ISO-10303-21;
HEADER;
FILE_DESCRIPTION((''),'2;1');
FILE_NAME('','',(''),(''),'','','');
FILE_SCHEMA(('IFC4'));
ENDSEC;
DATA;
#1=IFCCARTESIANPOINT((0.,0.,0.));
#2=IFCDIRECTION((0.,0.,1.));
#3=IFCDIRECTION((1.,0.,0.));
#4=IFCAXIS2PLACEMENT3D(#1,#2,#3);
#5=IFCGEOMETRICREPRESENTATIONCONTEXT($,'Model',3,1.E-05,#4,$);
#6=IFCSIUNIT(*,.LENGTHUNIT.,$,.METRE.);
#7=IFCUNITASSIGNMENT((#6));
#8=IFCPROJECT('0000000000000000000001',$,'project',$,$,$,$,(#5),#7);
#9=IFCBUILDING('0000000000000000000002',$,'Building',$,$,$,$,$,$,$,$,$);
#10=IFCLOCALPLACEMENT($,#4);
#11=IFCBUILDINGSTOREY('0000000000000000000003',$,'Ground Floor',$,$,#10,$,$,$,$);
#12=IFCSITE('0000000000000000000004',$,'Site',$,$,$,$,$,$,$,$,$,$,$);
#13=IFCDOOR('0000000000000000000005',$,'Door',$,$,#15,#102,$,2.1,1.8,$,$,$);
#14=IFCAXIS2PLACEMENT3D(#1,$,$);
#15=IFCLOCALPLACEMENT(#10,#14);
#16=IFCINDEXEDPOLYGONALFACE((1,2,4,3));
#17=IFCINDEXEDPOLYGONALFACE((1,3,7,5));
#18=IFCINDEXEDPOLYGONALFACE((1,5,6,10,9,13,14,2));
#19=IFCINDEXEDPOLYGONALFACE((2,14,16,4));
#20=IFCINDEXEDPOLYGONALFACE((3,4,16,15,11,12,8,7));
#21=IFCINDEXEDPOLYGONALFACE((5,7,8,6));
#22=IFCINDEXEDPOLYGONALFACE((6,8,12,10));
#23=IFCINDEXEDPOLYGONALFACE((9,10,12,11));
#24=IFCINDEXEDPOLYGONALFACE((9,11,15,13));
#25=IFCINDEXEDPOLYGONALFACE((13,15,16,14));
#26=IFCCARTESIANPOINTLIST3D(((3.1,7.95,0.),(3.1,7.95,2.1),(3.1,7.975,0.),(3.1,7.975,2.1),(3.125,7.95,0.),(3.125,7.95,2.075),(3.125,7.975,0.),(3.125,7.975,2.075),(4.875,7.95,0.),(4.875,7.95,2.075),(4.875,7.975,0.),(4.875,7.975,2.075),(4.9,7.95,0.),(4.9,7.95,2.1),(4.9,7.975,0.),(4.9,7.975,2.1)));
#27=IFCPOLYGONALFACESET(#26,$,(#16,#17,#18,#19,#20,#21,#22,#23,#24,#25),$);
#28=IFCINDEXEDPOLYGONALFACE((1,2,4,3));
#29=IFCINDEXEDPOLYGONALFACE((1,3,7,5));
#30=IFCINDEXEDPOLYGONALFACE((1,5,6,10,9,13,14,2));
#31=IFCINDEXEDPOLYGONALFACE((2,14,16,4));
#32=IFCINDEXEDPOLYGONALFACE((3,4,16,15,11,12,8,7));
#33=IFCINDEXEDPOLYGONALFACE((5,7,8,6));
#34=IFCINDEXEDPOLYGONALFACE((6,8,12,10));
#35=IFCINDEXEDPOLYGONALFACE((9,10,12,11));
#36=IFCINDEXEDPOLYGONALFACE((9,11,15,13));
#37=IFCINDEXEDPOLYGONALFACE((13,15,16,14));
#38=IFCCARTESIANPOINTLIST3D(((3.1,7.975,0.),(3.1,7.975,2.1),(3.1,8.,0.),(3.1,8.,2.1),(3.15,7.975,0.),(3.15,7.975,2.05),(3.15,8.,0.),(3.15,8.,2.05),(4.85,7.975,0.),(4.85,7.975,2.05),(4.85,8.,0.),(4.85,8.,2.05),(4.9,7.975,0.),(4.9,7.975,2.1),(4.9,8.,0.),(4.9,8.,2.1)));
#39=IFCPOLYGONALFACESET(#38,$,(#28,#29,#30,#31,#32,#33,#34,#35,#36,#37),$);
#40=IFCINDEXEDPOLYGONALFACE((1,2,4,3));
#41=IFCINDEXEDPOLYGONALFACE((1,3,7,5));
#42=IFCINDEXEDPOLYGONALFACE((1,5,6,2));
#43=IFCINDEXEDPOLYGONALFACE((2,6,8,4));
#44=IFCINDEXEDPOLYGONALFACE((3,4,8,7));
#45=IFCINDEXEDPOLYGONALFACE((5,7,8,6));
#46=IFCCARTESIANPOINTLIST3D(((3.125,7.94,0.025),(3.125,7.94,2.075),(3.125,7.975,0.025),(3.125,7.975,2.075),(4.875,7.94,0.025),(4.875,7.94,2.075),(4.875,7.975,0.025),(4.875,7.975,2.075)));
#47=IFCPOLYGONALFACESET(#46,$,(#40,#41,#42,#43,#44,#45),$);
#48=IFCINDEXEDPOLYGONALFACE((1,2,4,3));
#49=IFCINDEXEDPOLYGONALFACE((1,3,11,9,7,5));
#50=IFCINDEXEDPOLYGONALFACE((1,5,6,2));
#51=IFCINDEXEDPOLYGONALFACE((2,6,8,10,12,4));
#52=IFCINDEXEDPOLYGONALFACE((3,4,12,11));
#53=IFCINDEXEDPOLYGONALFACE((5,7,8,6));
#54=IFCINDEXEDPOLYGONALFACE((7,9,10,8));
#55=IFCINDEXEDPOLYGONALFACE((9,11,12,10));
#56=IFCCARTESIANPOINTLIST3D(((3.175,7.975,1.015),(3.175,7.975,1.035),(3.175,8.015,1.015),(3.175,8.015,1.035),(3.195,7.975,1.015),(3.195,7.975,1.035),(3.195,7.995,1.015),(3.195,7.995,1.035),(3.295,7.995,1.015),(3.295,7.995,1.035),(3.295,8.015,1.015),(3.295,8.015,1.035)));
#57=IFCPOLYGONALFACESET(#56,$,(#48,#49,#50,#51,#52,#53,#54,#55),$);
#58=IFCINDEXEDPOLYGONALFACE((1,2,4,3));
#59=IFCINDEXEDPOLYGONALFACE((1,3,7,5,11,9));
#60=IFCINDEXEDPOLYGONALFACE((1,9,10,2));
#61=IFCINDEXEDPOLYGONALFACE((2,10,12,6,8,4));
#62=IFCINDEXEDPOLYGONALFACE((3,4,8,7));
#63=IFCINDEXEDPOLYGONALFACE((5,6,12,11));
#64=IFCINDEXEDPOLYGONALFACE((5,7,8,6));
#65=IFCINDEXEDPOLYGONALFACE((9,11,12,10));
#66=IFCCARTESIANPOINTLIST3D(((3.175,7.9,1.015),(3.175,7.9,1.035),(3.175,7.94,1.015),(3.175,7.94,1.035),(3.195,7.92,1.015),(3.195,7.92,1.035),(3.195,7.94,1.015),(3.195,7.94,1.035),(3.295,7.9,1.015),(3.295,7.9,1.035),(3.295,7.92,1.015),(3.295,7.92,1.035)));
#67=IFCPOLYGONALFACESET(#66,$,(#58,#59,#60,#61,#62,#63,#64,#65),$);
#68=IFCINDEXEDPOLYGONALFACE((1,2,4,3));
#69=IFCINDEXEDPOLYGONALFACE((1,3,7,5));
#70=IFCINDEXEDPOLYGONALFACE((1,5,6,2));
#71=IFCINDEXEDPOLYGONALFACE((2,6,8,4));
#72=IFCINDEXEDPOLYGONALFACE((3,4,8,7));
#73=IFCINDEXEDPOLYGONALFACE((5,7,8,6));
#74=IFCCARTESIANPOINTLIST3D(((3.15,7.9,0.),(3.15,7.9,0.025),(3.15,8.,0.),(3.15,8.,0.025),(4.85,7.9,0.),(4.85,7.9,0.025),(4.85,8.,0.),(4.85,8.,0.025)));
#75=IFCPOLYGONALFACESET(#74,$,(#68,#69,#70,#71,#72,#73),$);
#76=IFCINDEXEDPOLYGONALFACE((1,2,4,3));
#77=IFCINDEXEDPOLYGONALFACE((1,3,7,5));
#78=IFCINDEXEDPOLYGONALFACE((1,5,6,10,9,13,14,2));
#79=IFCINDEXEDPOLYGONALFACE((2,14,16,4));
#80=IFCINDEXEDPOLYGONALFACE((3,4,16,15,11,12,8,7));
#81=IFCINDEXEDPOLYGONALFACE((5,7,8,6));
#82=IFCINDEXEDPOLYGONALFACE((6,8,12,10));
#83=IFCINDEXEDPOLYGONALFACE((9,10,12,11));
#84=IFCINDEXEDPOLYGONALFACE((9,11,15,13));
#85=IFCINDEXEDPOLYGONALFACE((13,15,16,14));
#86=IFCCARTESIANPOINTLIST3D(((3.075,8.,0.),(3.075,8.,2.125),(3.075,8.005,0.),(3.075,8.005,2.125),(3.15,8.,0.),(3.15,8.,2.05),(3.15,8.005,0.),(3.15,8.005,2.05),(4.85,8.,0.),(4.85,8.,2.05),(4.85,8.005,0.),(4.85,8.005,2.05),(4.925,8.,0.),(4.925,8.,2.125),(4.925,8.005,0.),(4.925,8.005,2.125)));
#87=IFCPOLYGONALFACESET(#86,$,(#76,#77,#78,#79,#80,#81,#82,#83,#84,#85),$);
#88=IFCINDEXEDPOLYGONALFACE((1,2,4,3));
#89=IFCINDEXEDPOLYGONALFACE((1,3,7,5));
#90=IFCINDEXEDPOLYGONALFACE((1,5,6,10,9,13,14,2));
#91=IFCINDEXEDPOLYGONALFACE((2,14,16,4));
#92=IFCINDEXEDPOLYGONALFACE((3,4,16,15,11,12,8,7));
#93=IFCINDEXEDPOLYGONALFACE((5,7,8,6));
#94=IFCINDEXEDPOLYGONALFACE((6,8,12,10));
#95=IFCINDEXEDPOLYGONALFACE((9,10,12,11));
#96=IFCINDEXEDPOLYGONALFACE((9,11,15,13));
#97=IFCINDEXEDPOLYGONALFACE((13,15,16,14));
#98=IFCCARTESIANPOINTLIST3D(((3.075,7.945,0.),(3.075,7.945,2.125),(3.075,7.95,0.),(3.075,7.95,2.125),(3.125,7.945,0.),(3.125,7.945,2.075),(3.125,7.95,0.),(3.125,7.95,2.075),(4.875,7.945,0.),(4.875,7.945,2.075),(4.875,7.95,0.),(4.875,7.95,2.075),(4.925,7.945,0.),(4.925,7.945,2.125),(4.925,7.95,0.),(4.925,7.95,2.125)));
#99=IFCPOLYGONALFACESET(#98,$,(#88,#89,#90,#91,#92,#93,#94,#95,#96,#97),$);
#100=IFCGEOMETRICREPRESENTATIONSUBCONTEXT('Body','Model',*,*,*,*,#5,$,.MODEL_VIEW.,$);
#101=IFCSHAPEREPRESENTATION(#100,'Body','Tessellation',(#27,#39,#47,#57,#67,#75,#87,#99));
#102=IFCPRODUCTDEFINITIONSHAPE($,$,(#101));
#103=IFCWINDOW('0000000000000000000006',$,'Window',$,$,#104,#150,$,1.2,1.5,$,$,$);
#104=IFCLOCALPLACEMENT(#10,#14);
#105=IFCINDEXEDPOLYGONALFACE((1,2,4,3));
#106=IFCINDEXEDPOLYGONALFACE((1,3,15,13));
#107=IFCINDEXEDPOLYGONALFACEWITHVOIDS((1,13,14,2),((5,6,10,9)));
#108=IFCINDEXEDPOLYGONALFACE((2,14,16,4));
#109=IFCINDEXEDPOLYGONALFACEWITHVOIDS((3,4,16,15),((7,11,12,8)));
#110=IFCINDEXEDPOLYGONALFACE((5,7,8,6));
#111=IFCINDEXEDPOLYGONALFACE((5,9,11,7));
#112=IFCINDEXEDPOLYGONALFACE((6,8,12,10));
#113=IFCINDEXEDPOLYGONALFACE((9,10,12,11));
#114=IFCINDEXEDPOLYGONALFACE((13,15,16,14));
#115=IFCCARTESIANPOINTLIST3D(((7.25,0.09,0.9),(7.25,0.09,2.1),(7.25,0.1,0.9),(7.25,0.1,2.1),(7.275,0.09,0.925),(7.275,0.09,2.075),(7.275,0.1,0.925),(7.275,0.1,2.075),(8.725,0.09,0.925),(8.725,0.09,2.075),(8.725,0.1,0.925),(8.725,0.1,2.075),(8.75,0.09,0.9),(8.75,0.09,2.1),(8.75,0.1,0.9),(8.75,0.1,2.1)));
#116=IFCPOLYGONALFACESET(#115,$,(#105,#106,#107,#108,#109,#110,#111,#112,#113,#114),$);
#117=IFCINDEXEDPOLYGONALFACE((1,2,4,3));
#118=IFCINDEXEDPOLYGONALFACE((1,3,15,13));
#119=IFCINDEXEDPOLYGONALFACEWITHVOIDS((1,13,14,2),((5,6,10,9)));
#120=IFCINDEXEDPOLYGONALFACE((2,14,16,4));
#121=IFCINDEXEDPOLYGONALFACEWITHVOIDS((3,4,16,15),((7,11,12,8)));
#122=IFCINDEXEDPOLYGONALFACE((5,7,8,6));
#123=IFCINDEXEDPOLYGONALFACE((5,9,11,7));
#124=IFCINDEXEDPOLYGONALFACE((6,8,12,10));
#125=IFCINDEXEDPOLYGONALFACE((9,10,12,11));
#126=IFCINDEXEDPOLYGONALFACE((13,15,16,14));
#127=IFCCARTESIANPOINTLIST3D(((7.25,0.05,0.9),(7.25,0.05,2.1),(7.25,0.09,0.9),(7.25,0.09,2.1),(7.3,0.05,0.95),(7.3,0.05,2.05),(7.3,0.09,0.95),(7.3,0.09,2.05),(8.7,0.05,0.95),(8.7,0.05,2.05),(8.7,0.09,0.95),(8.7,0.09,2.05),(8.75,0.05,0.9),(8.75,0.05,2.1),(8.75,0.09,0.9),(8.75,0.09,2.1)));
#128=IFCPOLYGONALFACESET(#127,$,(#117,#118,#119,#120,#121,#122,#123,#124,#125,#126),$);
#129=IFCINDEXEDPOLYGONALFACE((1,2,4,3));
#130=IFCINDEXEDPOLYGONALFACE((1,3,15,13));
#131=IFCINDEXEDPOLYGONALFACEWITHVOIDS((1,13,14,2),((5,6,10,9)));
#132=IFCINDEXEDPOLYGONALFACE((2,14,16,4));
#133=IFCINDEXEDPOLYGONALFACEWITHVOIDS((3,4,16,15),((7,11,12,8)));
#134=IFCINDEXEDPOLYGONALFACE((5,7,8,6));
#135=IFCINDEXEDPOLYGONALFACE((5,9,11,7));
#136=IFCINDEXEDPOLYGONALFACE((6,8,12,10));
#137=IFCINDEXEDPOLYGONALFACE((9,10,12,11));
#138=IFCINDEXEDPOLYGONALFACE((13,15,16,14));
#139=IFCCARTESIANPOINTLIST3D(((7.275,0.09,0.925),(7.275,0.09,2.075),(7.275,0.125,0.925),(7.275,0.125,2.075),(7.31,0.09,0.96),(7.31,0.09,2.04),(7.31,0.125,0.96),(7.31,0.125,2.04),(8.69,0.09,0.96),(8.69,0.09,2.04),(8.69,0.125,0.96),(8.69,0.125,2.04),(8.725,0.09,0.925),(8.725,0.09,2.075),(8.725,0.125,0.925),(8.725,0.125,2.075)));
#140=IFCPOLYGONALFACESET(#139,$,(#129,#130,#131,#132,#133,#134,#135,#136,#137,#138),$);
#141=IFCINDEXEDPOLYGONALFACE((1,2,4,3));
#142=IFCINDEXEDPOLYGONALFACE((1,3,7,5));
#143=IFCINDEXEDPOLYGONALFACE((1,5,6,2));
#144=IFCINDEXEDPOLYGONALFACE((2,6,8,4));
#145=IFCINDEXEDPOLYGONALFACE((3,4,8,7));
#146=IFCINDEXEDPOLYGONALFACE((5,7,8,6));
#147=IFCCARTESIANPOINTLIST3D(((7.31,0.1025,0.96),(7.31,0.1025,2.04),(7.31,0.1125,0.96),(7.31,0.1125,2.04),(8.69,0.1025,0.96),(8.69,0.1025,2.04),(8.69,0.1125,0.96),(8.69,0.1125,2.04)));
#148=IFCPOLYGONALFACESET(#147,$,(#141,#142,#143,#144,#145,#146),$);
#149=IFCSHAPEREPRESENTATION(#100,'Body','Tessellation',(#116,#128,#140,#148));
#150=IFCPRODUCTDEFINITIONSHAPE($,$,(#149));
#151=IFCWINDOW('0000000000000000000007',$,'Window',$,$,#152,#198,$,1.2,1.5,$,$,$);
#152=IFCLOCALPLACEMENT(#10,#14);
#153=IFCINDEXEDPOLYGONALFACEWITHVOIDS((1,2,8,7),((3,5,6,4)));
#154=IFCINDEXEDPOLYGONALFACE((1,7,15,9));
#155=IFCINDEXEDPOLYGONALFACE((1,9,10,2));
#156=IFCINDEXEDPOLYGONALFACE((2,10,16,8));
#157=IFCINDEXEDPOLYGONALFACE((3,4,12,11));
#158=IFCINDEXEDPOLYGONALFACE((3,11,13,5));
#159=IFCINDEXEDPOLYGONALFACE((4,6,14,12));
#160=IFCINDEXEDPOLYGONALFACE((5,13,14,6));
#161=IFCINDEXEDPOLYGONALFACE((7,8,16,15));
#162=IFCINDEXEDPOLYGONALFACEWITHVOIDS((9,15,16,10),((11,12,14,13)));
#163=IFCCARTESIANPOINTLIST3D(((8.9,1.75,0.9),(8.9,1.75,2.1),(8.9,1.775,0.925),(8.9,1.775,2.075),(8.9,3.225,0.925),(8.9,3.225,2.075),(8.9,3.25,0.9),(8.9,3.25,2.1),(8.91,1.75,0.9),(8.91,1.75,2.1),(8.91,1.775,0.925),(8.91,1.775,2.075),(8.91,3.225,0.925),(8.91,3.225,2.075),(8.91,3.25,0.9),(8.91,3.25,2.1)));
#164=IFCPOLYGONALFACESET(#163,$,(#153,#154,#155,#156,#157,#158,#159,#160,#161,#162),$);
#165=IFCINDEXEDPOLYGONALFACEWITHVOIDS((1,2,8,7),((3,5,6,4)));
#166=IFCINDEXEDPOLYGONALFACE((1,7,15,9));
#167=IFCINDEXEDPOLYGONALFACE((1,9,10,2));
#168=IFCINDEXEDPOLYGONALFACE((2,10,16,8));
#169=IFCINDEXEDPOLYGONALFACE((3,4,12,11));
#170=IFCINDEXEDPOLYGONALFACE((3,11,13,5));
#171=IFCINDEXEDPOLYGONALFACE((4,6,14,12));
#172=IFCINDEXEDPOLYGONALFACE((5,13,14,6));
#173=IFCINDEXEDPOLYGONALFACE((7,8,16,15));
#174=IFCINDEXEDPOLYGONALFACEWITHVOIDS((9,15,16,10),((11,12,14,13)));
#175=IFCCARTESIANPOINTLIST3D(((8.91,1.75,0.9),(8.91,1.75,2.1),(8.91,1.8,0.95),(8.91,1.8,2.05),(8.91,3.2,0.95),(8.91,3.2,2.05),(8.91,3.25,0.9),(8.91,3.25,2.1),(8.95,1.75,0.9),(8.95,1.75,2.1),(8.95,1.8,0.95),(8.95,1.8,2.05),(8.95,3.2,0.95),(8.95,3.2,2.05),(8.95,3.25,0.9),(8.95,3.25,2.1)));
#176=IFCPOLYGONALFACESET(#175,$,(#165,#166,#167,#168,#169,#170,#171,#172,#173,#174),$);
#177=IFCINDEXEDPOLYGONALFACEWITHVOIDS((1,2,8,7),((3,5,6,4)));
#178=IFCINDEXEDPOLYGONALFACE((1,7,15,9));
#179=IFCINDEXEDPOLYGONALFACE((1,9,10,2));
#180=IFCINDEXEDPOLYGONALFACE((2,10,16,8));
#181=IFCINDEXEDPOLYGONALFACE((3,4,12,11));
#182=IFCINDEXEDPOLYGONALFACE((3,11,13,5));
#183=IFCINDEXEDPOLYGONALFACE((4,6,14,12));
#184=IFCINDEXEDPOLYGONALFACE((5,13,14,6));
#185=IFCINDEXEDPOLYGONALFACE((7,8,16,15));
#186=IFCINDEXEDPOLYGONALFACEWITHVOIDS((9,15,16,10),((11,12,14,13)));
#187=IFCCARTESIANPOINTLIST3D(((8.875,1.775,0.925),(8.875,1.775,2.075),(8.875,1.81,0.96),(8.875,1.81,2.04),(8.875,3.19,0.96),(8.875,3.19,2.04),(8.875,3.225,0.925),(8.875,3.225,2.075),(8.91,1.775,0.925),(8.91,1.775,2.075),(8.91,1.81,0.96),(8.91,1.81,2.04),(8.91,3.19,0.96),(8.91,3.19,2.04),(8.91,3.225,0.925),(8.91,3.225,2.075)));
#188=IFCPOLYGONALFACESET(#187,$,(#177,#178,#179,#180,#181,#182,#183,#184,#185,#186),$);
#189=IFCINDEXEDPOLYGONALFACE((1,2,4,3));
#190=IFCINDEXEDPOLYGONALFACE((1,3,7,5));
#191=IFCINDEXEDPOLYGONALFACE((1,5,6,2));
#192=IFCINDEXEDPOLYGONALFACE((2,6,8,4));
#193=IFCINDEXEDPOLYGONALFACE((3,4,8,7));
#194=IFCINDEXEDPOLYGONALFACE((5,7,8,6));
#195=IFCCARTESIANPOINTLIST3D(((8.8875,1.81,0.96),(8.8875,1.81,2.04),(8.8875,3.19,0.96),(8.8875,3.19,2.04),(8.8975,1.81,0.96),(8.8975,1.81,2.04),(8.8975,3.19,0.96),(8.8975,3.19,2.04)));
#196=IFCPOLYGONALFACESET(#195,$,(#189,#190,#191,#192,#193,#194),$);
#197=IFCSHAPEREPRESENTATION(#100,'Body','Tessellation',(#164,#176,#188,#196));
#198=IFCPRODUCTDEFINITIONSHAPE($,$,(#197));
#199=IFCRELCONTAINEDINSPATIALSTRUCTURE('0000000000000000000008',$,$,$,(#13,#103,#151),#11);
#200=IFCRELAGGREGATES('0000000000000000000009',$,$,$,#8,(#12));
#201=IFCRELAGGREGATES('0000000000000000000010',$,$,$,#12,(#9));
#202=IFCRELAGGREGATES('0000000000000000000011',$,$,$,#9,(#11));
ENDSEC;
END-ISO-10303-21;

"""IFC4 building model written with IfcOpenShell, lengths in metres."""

from ifc_helpers import new_model, si_unit, frame, origin_with_axes, place, context, subcontext, project, spatial, line, indexed_curve, outline, extrude, element, save


model = new_model("IFC4")

# Units and contexts
model_context = context("Model", 3, precision=1e-05, world=origin_with_axes())
body_context = subcontext(model_context, "Body", "Model", "MODEL_VIEW")
ifc_project = project(units=[si_unit("LENGTHUNIT", "METRE")], contexts=[model_context])

# Site, building, storey
site = spatial("IfcSite", under=ifc_project, Name="Site")
building = spatial("IfcBuilding", under=site, Name="Building")
storey_placement = place(None, origin_with_axes())
storey = spatial("IfcBuildingStorey", under=building, at=storey_placement, Name="Ground Floor")

# Door
door_1_placement = place(storey_placement, frame((4.9, 8.0, 0.0), z_axis=(0.0, 0.0, 1.0), x_axis=(-1.0, 0.0, 0.0)))
element("IfcDoor", 1, at=door_1_placement, inside=storey, Name="Door", OverallHeight=2.1, OverallWidth=1.8, context=body_context, shape_type="SweptSolid", body=[
    extrude(outline(indexed_curve([(0.0, 0.0), (0.0, 2.1), (1.8, 2.1), (1.8, 0.0), (1.775, 0.0), (1.775, 2.075), (0.025, 2.075), (0.025, 0.0)], segments=[line(1, 2, 3, 4, 5, 6, 7, 8, 1)])), frame((0.0, 0.025, 0.0), z_axis=(0.0, -1.0, 0.0), x_axis=(1.0, 0.0, 0.0)), (0.0, 0.0, -1.0), 0.025),
    extrude(outline(indexed_curve([(0.0, 0.0), (0.0, 2.1), (1.8, 2.1), (1.8, 0.0), (1.75, 0.0), (1.75, 2.05), (0.05, 2.05), (0.05, 0.0)], segments=[line(1, 2, 3, 4, 5, 6, 7, 8, 1)])), frame((0.0, 0.0, 0.0), z_axis=(0.0, -1.0, 0.0), x_axis=(1.0, 0.0, 0.0)), (0.0, 0.0, -1.0), 0.025),
    extrude(outline(indexed_curve([(0.0, 0.0), (1.75, 0.0), (1.75, 0.035), (0.0, 0.035)], segments=[line(1, 2, 3, 4, 1)])), frame((0.025, 0.025, 0.025), z_axis=(0.0, 0.0, 1.0), x_axis=(1.0, 0.0, 0.0)), (0.0, 0.0, 1.0), 2.05),
    extrude(outline(indexed_curve([(0.0, 0.0), (0.0, -0.04), (-0.12, -0.04), (-0.12, -0.02), (-0.02, -0.02), (-0.02, 0.0)], segments=[line(1, 2, 3, 4, 5, 6, 1)])), frame((1.725, 0.025, 1.015), z_axis=(0.0, 0.0, 1.0), x_axis=(1.0, 0.0, 0.0)), (0.0, 0.0, 1.0), 0.02),
    extrude(outline(indexed_curve([(0.0, 0.0), (0.0, 0.04), (-0.12, 0.04), (-0.12, 0.02), (-0.02, 0.02), (-0.02, 0.0)], segments=[line(1, 2, 3, 4, 5, 6, 1)])), frame((1.725, 0.06, 1.015), z_axis=(0.0, 0.0, 1.0), x_axis=(1.0, 0.0, 0.0)), (0.0, 0.0, 1.0), 0.02),
    extrude(outline(indexed_curve([(0.0, 0.0), (1.7, 0.0), (1.7, 0.1), (0.0, 0.1)], segments=[line(1, 2, 3, 4, 1)])), frame((0.05, 0.0, 0.0), z_axis=(0.0, 0.0, 1.0), x_axis=(1.0, 0.0, 0.0)), (0.0, 0.0, 1.0), 0.025),
    extrude(outline(indexed_curve([(0.0, 0.0), (0.0, 2.125), (1.85, 2.125), (1.85, 0.0), (1.775, 0.0), (1.775, 2.05), (0.075, 2.05), (0.075, 0.0)], segments=[line(1, 2, 3, 4, 5, 6, 7, 8, 1)])), frame((-0.025, -0.005, 0.0), z_axis=(0.0, -1.0, 0.0), x_axis=(1.0, 0.0, 0.0)), (0.0, 0.0, -1.0), 0.005),
    extrude(outline(indexed_curve([(0.0, 0.0), (0.0, 2.125), (1.85, 2.125), (1.85, 0.0), (1.8, 0.0), (1.8, 2.075), (0.05, 2.075), (0.05, 0.0)], segments=[line(1, 2, 3, 4, 5, 6, 7, 8, 1)])), frame((-0.025, 0.05, 0.0), z_axis=(0.0, -1.0, 0.0), x_axis=(1.0, 0.0, 0.0)), (0.0, 0.0, -1.0), 0.005),
])

# Windows
for number, where, z_axis, x_axis, name in (
    (2, (7.25, 0.0, 0.9), (0.0, 0.0, 1.0), (1.0, 0.0, 0.0), "Window"),
    (3, (9.0, 1.75, 0.9), (0.0, 0.0, 1.0), (0.0, 1.0, 0.0), "Window"),
):
    element("IfcWindow", number, at=place(storey_placement, frame(where, z_axis=z_axis, x_axis=x_axis)), inside=storey, Name=name, OverallHeight=1.2, OverallWidth=1.5, context=body_context, shape_type="SweptSolid", body=[
        extrude(outline(indexed_curve([(0.0, 0.0), (1.5, 0.0), (1.5, 1.2), (0.0, 1.2)], segments=[line(1, 2, 3, 4, 1)]), holes=[indexed_curve([(0.025, 0.025), (1.475, 0.025), (1.475, 1.175), (0.025, 1.175)], segments=[line(1, 2, 3, 4, 1)])]), frame((0.0, 0.09, 0.0), z_axis=(0.0, -1.0, 0.0), x_axis=(1.0, 0.0, 0.0)), (0.0, 0.0, -1.0), 0.01),
        extrude(outline(indexed_curve([(0.0, 0.0), (1.5, 0.0), (1.5, 1.2), (0.0, 1.2)], segments=[line(1, 2, 3, 4, 1)]), holes=[indexed_curve([(0.05, 0.05), (1.45, 0.05), (1.45, 1.15), (0.05, 1.15)], segments=[line(1, 2, 3, 4, 1)])]), frame((0.0, 0.05, 0.0), z_axis=(0.0, -1.0, 0.0), x_axis=(1.0, 0.0, 0.0)), (0.0, 0.0, -1.0), 0.04),
        extrude(outline(indexed_curve([(0.0, 0.0), (1.45, 0.0), (1.45, 1.15), (0.0, 1.15)], segments=[line(1, 2, 3, 4, 1)]), holes=[indexed_curve([(0.035, 0.035), (1.415, 0.035), (1.415, 1.115), (0.035, 1.115)], segments=[line(1, 2, 3, 4, 1)])]), frame((0.025, 0.09, 0.025), z_axis=(0.0, -1.0, 0.0), x_axis=(1.0, 0.0, 0.0)), (0.0, 0.0, -1.0), 0.035),
        extrude(outline(indexed_curve([(0.035, 0.035), (1.415, 0.035), (1.415, 1.115), (0.035, 1.115)], segments=[line(1, 2, 3, 4, 1)])), frame((0.025, 0.1025, 0.025), z_axis=(0.0, -1.0, 0.0), x_axis=(1.0, 0.0, 0.0)), (0.0, 0.0, -1.0), 0.01),
    ])

save(model, "model.ifc")
